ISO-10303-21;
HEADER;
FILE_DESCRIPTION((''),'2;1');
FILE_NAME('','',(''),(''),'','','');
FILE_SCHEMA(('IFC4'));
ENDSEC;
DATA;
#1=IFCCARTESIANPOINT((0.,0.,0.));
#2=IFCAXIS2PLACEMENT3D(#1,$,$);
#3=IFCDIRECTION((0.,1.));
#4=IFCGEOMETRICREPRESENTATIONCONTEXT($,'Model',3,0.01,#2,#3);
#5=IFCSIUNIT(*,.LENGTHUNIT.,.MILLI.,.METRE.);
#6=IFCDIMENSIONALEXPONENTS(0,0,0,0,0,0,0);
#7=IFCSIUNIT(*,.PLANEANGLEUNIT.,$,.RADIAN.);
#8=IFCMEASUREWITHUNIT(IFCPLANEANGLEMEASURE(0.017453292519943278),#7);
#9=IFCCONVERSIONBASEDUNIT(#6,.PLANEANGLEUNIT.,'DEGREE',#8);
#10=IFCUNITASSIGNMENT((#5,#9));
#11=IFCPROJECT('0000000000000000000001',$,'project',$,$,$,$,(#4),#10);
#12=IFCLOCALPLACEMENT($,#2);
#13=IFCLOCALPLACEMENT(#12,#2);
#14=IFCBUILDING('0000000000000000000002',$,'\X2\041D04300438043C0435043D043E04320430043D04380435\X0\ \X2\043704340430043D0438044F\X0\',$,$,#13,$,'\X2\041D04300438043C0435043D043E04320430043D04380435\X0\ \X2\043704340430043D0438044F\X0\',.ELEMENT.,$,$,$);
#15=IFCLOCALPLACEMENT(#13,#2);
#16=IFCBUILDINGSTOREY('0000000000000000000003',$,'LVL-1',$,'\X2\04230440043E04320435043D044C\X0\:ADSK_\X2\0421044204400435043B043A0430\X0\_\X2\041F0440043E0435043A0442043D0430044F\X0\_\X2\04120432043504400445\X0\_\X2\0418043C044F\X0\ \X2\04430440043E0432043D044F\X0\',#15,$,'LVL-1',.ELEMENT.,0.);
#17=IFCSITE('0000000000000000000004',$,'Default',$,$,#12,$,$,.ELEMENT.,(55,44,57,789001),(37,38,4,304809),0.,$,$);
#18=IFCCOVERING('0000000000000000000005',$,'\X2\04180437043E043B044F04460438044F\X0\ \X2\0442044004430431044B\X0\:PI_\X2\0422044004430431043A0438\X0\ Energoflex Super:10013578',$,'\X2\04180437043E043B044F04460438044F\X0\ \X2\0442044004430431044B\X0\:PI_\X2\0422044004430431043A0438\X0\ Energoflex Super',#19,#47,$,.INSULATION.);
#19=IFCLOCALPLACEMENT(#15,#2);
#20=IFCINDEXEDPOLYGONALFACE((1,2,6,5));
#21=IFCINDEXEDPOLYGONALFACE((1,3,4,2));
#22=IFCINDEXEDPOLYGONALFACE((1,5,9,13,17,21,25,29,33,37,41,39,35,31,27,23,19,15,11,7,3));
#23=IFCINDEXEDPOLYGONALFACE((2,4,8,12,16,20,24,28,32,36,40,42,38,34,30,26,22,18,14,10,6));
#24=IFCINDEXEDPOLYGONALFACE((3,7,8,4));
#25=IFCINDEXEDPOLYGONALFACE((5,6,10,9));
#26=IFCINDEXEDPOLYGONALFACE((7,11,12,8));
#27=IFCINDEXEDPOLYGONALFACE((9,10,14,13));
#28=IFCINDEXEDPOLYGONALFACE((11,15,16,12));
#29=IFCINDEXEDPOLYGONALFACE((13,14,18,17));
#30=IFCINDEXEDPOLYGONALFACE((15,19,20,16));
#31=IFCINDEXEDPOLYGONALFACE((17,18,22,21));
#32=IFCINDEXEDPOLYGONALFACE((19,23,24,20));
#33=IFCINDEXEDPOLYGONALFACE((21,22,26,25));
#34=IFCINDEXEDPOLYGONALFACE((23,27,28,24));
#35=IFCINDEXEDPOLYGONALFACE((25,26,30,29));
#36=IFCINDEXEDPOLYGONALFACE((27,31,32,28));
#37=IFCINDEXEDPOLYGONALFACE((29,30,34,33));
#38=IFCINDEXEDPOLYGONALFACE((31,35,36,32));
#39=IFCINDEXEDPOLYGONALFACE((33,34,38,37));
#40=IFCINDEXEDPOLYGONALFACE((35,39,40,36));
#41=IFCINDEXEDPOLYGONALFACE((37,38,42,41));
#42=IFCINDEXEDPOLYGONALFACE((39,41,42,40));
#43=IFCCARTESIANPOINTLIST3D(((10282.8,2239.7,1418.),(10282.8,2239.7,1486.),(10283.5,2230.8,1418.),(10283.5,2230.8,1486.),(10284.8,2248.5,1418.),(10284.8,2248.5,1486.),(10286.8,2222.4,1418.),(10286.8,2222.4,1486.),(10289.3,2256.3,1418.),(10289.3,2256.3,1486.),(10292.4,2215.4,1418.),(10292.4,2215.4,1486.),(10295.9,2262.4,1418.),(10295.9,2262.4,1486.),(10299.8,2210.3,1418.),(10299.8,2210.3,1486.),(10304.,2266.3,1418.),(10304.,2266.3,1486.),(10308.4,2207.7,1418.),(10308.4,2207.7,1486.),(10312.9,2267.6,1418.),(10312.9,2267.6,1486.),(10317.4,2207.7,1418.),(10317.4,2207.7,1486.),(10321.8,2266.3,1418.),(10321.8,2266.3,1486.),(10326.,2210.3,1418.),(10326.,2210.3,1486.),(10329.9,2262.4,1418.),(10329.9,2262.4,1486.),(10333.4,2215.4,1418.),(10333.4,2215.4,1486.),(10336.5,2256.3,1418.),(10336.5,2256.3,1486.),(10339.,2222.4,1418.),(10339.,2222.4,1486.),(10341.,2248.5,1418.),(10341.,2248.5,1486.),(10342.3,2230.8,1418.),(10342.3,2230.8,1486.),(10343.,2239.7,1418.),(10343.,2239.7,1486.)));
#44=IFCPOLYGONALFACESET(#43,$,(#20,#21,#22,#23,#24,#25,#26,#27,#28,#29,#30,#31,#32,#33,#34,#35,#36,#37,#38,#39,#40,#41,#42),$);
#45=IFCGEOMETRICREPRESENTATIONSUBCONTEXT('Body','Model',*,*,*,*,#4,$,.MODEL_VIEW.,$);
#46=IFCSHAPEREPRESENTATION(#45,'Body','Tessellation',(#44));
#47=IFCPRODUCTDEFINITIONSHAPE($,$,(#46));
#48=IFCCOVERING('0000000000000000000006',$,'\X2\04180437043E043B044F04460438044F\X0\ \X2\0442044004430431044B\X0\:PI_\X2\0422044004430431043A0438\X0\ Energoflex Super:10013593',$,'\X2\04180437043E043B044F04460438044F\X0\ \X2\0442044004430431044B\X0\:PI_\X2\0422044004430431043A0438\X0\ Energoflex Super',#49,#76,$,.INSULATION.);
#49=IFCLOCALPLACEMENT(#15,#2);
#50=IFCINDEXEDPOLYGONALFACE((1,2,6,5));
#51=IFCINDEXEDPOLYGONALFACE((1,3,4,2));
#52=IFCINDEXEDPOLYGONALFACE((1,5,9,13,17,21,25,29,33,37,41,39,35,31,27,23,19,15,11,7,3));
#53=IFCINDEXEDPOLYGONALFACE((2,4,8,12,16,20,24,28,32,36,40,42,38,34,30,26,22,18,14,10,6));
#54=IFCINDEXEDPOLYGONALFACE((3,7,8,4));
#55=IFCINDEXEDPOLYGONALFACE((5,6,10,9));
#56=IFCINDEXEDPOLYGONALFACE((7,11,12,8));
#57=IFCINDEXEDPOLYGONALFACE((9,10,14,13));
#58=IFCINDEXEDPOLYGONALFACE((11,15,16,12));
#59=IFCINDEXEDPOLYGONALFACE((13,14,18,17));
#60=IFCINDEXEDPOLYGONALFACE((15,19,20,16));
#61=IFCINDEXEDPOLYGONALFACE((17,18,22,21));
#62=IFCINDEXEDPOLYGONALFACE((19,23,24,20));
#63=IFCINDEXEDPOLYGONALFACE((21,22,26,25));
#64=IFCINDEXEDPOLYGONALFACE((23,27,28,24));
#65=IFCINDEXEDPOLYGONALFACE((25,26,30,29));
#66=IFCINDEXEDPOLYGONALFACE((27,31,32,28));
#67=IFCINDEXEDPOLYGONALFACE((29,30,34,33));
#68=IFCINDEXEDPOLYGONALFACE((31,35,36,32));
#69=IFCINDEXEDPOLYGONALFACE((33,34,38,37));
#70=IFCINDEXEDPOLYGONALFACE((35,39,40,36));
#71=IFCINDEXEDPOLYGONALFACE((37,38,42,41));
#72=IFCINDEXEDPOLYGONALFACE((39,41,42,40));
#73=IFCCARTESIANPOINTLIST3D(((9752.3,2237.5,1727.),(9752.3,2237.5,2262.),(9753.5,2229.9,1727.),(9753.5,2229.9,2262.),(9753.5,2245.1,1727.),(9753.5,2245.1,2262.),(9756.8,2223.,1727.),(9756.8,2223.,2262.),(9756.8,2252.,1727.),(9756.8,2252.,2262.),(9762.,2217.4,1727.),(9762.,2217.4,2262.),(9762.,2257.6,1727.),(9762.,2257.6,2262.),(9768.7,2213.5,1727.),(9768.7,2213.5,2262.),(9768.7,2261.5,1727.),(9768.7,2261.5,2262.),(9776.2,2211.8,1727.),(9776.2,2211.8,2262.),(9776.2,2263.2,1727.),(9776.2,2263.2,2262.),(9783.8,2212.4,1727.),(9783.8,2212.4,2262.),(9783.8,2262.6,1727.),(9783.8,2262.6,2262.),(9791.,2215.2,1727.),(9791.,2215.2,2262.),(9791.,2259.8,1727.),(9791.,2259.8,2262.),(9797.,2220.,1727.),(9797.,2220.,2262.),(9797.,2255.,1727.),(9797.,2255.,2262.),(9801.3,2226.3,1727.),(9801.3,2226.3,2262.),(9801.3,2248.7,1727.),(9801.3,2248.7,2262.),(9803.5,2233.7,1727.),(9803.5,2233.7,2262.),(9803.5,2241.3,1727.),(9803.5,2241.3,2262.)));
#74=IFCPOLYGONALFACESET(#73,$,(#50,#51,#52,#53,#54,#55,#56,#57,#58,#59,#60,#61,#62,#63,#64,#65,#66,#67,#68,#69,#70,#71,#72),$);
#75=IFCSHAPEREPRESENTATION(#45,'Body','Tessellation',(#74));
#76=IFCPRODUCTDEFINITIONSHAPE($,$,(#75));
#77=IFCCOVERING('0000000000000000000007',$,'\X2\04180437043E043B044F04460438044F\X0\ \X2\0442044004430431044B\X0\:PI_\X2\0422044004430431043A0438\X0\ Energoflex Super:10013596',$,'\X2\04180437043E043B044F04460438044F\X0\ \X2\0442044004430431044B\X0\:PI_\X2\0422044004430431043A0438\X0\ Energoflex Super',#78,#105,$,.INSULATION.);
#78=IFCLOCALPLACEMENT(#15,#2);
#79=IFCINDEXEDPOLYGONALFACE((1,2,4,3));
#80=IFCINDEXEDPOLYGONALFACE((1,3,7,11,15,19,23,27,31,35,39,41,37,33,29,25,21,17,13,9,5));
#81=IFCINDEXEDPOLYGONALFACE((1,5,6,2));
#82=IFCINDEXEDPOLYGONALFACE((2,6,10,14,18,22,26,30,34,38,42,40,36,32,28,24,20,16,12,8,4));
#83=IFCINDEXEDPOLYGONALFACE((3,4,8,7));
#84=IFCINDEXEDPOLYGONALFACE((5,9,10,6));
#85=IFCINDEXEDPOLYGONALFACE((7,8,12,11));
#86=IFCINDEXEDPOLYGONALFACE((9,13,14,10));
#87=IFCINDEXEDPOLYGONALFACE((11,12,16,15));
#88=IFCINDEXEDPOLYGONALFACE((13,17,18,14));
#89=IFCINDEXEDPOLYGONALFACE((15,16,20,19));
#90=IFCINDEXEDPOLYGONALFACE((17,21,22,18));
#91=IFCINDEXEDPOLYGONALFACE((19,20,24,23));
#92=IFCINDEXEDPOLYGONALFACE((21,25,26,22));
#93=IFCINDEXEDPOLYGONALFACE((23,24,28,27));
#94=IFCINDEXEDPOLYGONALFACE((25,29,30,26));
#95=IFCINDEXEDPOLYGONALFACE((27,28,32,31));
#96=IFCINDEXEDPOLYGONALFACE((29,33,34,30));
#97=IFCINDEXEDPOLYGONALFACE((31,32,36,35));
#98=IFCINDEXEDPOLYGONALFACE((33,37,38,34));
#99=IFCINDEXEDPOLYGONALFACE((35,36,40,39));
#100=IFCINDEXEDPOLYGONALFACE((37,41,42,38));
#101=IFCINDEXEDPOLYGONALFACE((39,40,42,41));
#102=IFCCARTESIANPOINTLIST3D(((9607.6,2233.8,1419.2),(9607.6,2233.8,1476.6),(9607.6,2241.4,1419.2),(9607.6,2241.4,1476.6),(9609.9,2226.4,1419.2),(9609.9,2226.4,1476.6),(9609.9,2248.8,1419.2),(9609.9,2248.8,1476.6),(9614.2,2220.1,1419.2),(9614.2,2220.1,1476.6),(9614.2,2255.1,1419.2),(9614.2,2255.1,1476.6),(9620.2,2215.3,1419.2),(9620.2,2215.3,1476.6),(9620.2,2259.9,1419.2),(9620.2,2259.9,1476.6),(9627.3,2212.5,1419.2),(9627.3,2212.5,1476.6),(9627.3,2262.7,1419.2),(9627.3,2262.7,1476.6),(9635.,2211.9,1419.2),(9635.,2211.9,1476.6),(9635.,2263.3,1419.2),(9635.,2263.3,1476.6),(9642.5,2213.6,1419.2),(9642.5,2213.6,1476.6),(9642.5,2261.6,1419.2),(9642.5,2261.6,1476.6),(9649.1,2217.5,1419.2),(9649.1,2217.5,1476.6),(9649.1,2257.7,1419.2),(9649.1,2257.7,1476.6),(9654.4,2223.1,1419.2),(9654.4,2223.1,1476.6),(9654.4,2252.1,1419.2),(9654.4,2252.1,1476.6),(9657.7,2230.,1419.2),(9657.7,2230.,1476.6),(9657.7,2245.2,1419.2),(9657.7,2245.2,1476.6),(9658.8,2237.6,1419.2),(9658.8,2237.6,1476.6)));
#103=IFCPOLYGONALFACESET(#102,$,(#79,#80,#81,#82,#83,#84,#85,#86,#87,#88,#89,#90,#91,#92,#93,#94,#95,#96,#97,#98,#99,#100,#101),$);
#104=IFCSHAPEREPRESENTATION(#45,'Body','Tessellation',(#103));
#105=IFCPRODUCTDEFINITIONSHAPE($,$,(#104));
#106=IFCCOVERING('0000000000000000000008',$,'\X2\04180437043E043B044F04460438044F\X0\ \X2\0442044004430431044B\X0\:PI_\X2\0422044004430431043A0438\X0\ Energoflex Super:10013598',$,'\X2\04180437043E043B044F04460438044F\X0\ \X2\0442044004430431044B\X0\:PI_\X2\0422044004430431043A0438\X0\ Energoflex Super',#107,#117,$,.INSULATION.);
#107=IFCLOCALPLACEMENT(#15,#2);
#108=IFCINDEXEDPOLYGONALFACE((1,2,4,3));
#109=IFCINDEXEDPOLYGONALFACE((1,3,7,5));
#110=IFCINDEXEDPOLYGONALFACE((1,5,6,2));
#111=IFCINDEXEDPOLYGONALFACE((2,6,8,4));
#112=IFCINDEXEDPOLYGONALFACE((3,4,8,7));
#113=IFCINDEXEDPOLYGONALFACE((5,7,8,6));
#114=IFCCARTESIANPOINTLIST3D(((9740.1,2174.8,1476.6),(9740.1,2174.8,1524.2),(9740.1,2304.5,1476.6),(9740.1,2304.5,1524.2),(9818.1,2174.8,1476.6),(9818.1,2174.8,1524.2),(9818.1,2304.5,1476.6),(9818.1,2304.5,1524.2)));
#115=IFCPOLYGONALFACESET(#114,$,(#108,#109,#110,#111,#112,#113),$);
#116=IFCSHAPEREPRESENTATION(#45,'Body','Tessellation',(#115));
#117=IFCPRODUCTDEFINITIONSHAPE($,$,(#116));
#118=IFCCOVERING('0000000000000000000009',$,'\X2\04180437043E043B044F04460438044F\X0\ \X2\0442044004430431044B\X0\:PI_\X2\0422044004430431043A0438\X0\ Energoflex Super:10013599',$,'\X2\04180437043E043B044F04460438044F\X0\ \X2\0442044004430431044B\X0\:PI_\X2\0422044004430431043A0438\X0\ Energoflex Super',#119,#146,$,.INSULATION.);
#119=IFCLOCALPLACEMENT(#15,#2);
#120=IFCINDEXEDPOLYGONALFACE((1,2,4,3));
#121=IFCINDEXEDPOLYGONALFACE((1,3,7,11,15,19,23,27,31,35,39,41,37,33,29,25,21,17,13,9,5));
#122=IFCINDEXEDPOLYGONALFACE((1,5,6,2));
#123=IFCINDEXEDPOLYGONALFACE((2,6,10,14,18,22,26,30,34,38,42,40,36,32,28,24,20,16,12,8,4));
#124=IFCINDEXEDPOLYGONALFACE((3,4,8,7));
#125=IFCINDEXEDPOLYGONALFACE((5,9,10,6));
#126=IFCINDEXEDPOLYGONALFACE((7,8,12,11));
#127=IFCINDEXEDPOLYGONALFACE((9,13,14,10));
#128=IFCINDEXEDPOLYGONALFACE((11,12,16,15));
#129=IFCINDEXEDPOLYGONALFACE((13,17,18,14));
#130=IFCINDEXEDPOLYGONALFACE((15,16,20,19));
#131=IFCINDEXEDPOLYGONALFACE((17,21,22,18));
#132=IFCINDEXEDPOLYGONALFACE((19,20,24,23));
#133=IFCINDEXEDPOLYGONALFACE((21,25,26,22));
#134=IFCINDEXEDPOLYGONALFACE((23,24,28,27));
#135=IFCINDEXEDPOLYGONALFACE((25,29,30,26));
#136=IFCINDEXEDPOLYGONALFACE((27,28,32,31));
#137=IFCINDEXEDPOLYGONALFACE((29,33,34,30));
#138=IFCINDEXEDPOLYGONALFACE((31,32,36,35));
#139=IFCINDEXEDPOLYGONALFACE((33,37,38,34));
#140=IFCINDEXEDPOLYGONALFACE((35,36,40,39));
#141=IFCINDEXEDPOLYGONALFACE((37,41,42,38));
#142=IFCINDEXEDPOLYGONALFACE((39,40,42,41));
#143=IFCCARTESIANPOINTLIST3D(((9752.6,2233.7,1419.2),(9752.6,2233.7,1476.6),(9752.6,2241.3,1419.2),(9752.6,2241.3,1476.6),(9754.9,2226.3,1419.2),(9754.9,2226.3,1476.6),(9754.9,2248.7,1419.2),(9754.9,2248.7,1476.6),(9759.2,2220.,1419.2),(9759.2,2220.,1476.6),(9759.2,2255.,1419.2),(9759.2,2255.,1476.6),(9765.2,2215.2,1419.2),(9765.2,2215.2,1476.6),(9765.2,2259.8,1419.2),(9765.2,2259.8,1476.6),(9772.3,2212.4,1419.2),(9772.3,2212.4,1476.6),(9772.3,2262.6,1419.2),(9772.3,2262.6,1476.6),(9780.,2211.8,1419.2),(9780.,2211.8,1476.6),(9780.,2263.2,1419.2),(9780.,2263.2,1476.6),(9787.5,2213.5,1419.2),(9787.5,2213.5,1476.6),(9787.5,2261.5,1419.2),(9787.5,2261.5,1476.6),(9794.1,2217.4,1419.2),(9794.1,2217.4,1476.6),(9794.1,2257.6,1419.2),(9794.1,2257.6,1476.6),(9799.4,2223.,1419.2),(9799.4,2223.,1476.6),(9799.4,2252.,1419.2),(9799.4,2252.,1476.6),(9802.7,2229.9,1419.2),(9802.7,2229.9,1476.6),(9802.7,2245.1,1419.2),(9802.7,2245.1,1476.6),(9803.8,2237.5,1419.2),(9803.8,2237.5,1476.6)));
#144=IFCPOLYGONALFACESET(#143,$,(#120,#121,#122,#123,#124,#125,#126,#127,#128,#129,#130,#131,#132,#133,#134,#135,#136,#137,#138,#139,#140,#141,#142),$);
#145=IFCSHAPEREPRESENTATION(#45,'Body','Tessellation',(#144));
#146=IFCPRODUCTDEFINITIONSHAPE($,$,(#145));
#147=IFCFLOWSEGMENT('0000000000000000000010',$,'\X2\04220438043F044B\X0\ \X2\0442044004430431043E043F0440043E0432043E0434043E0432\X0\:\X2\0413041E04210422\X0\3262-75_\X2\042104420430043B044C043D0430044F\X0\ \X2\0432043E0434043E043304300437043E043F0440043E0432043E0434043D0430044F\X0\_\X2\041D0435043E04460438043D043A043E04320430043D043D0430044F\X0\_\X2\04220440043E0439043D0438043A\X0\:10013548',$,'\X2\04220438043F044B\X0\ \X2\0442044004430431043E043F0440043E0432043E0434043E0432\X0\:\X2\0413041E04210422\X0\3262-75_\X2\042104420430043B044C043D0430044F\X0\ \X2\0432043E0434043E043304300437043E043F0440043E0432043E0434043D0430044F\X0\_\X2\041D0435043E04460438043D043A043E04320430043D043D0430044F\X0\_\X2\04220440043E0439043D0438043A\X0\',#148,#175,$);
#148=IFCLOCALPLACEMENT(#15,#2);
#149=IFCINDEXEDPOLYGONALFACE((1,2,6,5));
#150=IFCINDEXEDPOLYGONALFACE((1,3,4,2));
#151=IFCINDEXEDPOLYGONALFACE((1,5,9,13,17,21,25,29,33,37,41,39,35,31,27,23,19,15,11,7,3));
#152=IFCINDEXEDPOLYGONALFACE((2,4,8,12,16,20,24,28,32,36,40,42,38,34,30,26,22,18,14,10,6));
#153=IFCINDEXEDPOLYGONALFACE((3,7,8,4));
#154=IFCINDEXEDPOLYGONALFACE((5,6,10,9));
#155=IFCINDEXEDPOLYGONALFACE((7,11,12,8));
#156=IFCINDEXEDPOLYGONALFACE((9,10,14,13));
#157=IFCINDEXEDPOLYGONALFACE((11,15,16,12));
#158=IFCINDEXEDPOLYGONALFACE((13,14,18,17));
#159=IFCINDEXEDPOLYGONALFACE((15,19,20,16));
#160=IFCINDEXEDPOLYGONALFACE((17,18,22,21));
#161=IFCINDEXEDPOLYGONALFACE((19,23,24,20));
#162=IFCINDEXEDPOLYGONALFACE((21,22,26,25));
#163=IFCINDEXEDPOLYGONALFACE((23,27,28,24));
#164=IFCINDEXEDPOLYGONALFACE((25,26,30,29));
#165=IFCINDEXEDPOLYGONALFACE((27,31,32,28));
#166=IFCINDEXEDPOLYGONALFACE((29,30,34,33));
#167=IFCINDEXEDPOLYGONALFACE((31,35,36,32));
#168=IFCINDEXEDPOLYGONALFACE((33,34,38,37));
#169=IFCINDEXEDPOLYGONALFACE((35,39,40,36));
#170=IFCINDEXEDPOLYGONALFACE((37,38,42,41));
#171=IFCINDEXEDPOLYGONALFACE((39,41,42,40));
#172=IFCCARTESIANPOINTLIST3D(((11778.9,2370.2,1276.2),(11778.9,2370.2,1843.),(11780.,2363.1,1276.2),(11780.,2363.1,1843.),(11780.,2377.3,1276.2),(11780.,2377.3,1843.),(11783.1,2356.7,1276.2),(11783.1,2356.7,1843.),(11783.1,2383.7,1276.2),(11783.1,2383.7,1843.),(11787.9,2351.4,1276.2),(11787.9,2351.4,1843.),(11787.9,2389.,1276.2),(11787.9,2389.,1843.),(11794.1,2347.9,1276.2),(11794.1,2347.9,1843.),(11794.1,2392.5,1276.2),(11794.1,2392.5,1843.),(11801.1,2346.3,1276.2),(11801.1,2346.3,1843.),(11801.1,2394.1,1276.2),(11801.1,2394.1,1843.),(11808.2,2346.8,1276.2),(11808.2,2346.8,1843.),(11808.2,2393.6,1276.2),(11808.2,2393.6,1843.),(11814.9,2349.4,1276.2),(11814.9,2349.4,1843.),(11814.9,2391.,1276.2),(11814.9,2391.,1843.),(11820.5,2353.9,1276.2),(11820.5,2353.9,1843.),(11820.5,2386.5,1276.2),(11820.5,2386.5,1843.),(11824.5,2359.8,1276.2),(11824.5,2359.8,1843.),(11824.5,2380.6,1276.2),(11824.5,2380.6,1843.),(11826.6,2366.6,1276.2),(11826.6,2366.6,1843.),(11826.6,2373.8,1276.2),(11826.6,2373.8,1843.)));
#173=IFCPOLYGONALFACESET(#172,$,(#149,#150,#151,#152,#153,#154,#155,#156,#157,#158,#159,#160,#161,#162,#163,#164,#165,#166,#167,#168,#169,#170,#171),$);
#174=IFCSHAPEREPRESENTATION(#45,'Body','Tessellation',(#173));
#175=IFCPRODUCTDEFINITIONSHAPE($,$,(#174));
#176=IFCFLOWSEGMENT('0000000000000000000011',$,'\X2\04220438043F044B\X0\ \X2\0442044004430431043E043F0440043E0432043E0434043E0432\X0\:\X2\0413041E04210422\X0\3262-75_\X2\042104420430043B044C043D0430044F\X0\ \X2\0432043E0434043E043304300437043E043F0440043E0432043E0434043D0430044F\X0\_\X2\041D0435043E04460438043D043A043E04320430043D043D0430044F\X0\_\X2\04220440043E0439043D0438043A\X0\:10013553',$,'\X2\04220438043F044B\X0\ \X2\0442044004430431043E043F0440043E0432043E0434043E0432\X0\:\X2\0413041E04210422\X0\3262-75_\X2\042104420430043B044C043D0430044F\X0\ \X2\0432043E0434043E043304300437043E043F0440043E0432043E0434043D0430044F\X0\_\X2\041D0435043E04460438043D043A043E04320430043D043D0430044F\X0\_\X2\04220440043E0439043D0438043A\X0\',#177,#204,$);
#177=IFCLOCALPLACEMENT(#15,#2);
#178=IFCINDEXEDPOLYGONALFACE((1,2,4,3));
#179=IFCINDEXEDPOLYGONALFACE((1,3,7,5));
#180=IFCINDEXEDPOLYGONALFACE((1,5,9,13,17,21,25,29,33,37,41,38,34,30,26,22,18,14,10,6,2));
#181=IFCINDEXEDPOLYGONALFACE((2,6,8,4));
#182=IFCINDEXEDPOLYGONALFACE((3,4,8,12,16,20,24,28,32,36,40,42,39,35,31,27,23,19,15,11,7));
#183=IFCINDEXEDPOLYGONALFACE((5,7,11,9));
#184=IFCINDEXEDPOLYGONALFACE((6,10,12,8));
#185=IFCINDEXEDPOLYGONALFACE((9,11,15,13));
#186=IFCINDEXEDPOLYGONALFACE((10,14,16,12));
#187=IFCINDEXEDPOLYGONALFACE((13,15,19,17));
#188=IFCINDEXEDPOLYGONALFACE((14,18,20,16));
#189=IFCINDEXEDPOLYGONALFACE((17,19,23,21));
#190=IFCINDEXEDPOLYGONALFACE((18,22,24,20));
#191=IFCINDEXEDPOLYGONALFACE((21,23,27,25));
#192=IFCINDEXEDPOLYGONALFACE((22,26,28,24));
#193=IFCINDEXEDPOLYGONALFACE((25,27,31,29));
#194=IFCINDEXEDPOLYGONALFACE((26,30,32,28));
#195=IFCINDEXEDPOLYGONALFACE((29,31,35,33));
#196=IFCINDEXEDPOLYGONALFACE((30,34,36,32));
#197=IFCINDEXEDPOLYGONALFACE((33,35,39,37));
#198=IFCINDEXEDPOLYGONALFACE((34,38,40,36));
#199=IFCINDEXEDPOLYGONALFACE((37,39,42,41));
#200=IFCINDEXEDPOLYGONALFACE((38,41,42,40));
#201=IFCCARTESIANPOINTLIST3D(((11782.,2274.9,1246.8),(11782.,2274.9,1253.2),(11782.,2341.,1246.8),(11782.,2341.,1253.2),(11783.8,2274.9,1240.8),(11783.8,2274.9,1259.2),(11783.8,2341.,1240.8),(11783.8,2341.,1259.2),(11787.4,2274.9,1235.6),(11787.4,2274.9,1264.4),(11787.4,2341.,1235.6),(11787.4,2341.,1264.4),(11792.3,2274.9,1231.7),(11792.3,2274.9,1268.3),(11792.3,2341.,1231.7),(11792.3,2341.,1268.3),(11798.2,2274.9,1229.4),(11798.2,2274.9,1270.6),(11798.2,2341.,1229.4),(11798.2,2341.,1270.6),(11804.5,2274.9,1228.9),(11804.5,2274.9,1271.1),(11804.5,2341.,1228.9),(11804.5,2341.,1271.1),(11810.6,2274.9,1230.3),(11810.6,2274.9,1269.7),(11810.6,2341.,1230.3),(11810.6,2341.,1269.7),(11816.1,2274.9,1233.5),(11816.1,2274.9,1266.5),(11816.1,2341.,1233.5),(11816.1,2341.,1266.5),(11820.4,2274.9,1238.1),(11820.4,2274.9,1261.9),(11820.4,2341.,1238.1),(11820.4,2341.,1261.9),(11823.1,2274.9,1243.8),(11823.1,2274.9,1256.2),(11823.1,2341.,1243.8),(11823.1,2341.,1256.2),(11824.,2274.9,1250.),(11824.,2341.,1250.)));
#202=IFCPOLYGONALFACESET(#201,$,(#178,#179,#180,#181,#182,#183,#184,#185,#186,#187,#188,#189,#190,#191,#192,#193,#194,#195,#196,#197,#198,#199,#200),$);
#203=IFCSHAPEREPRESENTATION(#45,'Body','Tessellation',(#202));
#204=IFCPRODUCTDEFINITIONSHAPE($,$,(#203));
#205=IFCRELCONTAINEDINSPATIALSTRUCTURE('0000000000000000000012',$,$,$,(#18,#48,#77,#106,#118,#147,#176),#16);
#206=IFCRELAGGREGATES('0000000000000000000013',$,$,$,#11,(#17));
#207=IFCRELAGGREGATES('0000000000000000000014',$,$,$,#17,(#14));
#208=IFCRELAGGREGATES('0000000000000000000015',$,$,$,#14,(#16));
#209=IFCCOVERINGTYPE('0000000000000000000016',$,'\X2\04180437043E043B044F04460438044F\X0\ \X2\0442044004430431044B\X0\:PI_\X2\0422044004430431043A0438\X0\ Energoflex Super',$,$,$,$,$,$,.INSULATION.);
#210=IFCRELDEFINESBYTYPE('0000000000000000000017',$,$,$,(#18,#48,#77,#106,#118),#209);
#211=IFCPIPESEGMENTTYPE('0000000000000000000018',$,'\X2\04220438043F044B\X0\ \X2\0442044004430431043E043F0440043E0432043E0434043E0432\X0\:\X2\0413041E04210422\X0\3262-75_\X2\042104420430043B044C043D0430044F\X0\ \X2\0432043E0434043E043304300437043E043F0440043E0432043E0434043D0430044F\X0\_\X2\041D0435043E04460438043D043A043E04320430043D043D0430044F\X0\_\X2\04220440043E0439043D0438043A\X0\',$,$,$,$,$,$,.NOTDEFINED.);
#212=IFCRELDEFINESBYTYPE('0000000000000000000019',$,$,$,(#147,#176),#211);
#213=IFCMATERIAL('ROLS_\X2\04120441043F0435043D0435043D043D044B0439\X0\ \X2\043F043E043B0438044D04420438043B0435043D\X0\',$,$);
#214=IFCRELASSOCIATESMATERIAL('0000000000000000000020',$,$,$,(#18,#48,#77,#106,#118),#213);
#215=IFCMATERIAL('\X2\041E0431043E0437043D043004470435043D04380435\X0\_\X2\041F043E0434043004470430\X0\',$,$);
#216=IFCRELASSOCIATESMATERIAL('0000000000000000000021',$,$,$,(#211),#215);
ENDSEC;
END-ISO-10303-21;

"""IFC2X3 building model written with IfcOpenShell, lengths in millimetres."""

from ifc_helpers import new_model, entity, si_unit, converted_unit, direction, frame, frame_2d, origin, origin_2d_with_axis, place, context, subcontext, project, spatial, rectangle, circle, extrude, material, type_object, element, save


model = new_model("IFC2X3")

# Units and contexts
model_context = context("Model", 3, precision=0.01, world=origin(), true_north=direction((0.0, 1.0)))
body_context = subcontext(model_context, "Body", "Model", "MODEL_VIEW")
ifc_project = project(units=[si_unit("LENGTHUNIT", "METRE", prefix="MILLI"), converted_unit("PLANEANGLEUNIT", "DEGREE", entity("IfcPlaneAngleMeasure", 0.017453292519943278), si_unit("PLANEANGLEUNIT", "RADIAN"), dimensions=[0, 0, 0, 0, 0, 0, 0])], contexts=[model_context])

# Site, building, storey
site_placement = place(None, origin())
site = spatial("IfcSite", under=ifc_project, at=site_placement, Name="Default", CompositionType="ELEMENT", RefLatitude=(55, 44, 57, 789001), RefLongitude=(37, 38, 4, 304809), RefElevation=0.0)
building_placement = place(site_placement, origin())
building = spatial("IfcBuilding", under=site, at=building_placement, Name="Наименование здания", LongName="Наименование здания", CompositionType="ELEMENT")
storey_placement = place(building_placement, origin())
storey = spatial("IfcBuildingStorey", under=building, at=storey_placement, Name="LVL-1", ObjectType="Уровень:ADSK_Стрелка_Проектная_Вверх_Имя уровня", LongName="LVL-1", CompositionType="ELEMENT", Elevation=0.0)

# Coverings
ifc_material_1 = material(Name="ROLS_Вспененный полиэтилен")
covering_type = type_object("IfcCoveringType", Name="Изоляция трубы:PI_Трубки Energoflex Super", PredefinedType="INSULATION")
covering_1_placement = place(storey_placement, origin())
element("IfcCovering", 1, at=covering_1_placement, inside=storey, type_object=covering_type, material=ifc_material_1, Name="Изоляция трубы:PI_Трубки Energoflex Super:10013578", ObjectType="Изоляция трубы:PI_Трубки Energoflex Super", PredefinedType="INSULATION", context=body_context, shape_type="SweptSolid", body=[
    extrude(circle(Radius=30.1, at=frame_2d((0.0, 0.0), x_axis=(1.0, 0.0))), frame((10312.9, 2237.5, 1418.0), z_axis=(0.0, 0.0, 1.0), x_axis=(0.866025, -0.5, 0.0)), (0.0, 0.0, 1.0), 68.0),
])
covering_2_placement = place(storey_placement, origin())
element("IfcCovering", 2, at=covering_2_placement, inside=storey, type_object=covering_type, material=ifc_material_1, Name="Изоляция трубы:PI_Трубки Energoflex Super:10013593", ObjectType="Изоляция трубы:PI_Трубки Energoflex Super", PredefinedType="INSULATION", context=body_context, shape_type="SweptSolid", body=[
    extrude(circle(Radius=25.8, at=frame_2d((0.0, 0.0), x_axis=(1.0, 0.0))), frame((9778.1, 2237.5, 1727.0), z_axis=(0.0, 0.0, 1.0), x_axis=(-1.0, 0.0, 0.0)), (0.0, 0.0, 1.0), 535.0),
])
covering_3_placement = place(storey_placement, origin())
element("IfcCovering", 3, at=covering_3_placement, inside=storey, type_object=covering_type, material=ifc_material_1, Name="Изоляция трубы:PI_Трубки Energoflex Super:10013596", ObjectType="Изоляция трубы:PI_Трубки Energoflex Super", PredefinedType="INSULATION", context=body_context, shape_type="SweptSolid", body=[
    extrude(circle(Radius=25.8, at=origin_2d_with_axis()), frame((9633.1, 2237.6, 1419.2)), (0.0, 0.0, 1.0), 57.4),
])
covering_4_placement = place(storey_placement, origin())
element("IfcCovering", 4, at=covering_4_placement, inside=storey, type_object=covering_type, material=ifc_material_1, Name="Изоляция трубы:PI_Трубки Energoflex Super:10013598", ObjectType="Изоляция трубы:PI_Трубки Energoflex Super", PredefinedType="INSULATION", context=body_context, shape_type="SweptSolid", body=[
    extrude(rectangle(XDim=78.0, YDim=129.7, at=origin_2d_with_axis()), frame((9779.1, 2239.6, 1476.6)), (0.0, 0.0, 1.0), 47.7),
])
covering_5_placement = place(storey_placement, origin())
element("IfcCovering", 5, at=covering_5_placement, inside=storey, type_object=covering_type, material=ifc_material_1, Name="Изоляция трубы:PI_Трубки Energoflex Super:10013599", ObjectType="Изоляция трубы:PI_Трубки Energoflex Super", PredefinedType="INSULATION", context=body_context, shape_type="SweptSolid", body=[
    extrude(circle(Radius=25.8, at=origin_2d_with_axis()), frame((9778.1, 2237.5, 1419.2)), (0.0, 0.0, 1.0), 57.4),
])

# Flow segments
ifc_material_2 = material(Name="Обозначение_Подача")
pipe_segment_type_1 = type_object("IfcPipeSegmentType", Name="Типы трубопроводов:ГОСТ3262-75_Стальная водогазопроводная_Неоцинкованная_Тройник", PredefinedType="NOTDEFINED", material=ifc_material_2)
flow_segment_1_placement = place(storey_placement, origin())
element("IfcFlowSegment", 6, at=flow_segment_1_placement, inside=storey, type_object=pipe_segment_type_1, Name="Типы трубопроводов:ГОСТ3262-75_Стальная водогазопроводная_Неоцинкованная_Тройник:10013548", ObjectType="Типы трубопроводов:ГОСТ3262-75_Стальная водогазопроводная_Неоцинкованная_Тройник", context=body_context, shape_type="SweptSolid", body=[
    extrude(circle(Radius=24.0, at=origin_2d_with_axis()), frame((11802.9, 2370.2, 1276.2), z_axis=(0.0, 0.0, 1.0), x_axis=(-1.0, 0.0, 0.0)), (0.0, 0.0, 1.0), 566.8),
])
flow_segment_2_placement = place(storey_placement, origin())
element("IfcFlowSegment", 7, at=flow_segment_2_placement, inside=storey, type_object=pipe_segment_type_1, Name="Типы трубопроводов:ГОСТ3262-75_Стальная водогазопроводная_Неоцинкованная_Тройник:10013553", ObjectType="Типы трубопроводов:ГОСТ3262-75_Стальная водогазопроводная_Неоцинкованная_Тройник", context=body_context, shape_type="SweptSolid", body=[
    extrude(circle(Radius=21.1, at=origin_2d_with_axis()), frame((11802.9, 2274.9, 1250.0), z_axis=(0.0, 1.0, 0.0), x_axis=(1.0, 0.0, 0.0)), (0.0, 0.0, 1.0), 66.1),
])

save(model, "model.ifc")
